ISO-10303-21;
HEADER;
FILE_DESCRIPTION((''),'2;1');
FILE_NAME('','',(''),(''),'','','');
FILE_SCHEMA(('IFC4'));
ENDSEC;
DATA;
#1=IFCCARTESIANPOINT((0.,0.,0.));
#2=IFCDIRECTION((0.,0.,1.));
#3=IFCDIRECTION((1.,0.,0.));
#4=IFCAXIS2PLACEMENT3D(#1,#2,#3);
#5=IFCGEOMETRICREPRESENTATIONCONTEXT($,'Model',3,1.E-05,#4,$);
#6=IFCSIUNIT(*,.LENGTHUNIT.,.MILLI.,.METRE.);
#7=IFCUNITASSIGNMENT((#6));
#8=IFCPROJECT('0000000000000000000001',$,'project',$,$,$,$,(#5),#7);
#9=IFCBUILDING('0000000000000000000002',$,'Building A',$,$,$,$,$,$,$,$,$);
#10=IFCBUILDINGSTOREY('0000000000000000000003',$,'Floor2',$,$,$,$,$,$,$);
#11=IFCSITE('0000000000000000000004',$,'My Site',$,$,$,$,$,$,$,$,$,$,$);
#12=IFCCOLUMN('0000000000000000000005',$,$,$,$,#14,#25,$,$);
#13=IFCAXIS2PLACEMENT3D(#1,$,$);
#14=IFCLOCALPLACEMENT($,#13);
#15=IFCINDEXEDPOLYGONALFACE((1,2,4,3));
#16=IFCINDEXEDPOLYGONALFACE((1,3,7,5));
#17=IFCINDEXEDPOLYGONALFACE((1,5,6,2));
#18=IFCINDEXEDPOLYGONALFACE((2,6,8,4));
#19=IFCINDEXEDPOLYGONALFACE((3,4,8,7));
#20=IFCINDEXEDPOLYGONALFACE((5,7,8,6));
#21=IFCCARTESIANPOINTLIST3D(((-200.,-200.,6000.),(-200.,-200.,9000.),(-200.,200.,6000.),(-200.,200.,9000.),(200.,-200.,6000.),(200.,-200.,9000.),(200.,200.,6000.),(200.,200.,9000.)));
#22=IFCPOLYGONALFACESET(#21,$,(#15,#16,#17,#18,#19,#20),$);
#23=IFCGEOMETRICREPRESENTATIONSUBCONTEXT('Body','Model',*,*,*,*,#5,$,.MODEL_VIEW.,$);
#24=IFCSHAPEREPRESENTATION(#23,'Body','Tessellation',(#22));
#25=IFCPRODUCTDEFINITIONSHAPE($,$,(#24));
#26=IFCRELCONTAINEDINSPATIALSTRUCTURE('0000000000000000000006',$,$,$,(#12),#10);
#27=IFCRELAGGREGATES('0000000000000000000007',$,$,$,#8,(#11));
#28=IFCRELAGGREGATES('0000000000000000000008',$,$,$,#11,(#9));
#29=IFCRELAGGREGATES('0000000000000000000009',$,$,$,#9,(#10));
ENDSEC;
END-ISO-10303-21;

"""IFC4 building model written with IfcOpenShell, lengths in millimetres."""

from ifc_helpers import new_model, si_unit, frame, origin_with_axes, place, context, subcontext, project, spatial, line, indexed_curve, outline, extrude, element, save


model = new_model("IFC4")

# Units and contexts
model_context = context("Model", 3, precision=1e-05, world=origin_with_axes())
body_context = subcontext(model_context, "Body", "Model", "MODEL_VIEW")
ifc_project = project(units=[si_unit("LENGTHUNIT", "METRE", prefix="MILLI")], contexts=[model_context])

# Site, building, storey
site = spatial("IfcSite", under=ifc_project, Name="My Site")
building = spatial("IfcBuilding", under=site, Name="Building A")
storey = spatial("IfcBuildingStorey", under=building, Name="Floor2")

# Column
column_placement = place(None, frame((0.0, 0.0, 6000.0), z_axis=(0.0, 0.0, 1.0), x_axis=(1.0, 0.0, 0.0)))
element("IfcColumn", 1, at=column_placement, inside=storey, context=body_context, shape_type="SweptSolid", body=[
    extrude(outline(indexed_curve([(-200.0, -200.0), (200.0, -200.0), (200.0, 200.0), (-200.0, 200.0)], segments=[line(1, 2, 3, 4, 1)])), origin_with_axes(), (0.0, 0.0, 1.0), 3000.0),
])

save(model, "model.ifc")
